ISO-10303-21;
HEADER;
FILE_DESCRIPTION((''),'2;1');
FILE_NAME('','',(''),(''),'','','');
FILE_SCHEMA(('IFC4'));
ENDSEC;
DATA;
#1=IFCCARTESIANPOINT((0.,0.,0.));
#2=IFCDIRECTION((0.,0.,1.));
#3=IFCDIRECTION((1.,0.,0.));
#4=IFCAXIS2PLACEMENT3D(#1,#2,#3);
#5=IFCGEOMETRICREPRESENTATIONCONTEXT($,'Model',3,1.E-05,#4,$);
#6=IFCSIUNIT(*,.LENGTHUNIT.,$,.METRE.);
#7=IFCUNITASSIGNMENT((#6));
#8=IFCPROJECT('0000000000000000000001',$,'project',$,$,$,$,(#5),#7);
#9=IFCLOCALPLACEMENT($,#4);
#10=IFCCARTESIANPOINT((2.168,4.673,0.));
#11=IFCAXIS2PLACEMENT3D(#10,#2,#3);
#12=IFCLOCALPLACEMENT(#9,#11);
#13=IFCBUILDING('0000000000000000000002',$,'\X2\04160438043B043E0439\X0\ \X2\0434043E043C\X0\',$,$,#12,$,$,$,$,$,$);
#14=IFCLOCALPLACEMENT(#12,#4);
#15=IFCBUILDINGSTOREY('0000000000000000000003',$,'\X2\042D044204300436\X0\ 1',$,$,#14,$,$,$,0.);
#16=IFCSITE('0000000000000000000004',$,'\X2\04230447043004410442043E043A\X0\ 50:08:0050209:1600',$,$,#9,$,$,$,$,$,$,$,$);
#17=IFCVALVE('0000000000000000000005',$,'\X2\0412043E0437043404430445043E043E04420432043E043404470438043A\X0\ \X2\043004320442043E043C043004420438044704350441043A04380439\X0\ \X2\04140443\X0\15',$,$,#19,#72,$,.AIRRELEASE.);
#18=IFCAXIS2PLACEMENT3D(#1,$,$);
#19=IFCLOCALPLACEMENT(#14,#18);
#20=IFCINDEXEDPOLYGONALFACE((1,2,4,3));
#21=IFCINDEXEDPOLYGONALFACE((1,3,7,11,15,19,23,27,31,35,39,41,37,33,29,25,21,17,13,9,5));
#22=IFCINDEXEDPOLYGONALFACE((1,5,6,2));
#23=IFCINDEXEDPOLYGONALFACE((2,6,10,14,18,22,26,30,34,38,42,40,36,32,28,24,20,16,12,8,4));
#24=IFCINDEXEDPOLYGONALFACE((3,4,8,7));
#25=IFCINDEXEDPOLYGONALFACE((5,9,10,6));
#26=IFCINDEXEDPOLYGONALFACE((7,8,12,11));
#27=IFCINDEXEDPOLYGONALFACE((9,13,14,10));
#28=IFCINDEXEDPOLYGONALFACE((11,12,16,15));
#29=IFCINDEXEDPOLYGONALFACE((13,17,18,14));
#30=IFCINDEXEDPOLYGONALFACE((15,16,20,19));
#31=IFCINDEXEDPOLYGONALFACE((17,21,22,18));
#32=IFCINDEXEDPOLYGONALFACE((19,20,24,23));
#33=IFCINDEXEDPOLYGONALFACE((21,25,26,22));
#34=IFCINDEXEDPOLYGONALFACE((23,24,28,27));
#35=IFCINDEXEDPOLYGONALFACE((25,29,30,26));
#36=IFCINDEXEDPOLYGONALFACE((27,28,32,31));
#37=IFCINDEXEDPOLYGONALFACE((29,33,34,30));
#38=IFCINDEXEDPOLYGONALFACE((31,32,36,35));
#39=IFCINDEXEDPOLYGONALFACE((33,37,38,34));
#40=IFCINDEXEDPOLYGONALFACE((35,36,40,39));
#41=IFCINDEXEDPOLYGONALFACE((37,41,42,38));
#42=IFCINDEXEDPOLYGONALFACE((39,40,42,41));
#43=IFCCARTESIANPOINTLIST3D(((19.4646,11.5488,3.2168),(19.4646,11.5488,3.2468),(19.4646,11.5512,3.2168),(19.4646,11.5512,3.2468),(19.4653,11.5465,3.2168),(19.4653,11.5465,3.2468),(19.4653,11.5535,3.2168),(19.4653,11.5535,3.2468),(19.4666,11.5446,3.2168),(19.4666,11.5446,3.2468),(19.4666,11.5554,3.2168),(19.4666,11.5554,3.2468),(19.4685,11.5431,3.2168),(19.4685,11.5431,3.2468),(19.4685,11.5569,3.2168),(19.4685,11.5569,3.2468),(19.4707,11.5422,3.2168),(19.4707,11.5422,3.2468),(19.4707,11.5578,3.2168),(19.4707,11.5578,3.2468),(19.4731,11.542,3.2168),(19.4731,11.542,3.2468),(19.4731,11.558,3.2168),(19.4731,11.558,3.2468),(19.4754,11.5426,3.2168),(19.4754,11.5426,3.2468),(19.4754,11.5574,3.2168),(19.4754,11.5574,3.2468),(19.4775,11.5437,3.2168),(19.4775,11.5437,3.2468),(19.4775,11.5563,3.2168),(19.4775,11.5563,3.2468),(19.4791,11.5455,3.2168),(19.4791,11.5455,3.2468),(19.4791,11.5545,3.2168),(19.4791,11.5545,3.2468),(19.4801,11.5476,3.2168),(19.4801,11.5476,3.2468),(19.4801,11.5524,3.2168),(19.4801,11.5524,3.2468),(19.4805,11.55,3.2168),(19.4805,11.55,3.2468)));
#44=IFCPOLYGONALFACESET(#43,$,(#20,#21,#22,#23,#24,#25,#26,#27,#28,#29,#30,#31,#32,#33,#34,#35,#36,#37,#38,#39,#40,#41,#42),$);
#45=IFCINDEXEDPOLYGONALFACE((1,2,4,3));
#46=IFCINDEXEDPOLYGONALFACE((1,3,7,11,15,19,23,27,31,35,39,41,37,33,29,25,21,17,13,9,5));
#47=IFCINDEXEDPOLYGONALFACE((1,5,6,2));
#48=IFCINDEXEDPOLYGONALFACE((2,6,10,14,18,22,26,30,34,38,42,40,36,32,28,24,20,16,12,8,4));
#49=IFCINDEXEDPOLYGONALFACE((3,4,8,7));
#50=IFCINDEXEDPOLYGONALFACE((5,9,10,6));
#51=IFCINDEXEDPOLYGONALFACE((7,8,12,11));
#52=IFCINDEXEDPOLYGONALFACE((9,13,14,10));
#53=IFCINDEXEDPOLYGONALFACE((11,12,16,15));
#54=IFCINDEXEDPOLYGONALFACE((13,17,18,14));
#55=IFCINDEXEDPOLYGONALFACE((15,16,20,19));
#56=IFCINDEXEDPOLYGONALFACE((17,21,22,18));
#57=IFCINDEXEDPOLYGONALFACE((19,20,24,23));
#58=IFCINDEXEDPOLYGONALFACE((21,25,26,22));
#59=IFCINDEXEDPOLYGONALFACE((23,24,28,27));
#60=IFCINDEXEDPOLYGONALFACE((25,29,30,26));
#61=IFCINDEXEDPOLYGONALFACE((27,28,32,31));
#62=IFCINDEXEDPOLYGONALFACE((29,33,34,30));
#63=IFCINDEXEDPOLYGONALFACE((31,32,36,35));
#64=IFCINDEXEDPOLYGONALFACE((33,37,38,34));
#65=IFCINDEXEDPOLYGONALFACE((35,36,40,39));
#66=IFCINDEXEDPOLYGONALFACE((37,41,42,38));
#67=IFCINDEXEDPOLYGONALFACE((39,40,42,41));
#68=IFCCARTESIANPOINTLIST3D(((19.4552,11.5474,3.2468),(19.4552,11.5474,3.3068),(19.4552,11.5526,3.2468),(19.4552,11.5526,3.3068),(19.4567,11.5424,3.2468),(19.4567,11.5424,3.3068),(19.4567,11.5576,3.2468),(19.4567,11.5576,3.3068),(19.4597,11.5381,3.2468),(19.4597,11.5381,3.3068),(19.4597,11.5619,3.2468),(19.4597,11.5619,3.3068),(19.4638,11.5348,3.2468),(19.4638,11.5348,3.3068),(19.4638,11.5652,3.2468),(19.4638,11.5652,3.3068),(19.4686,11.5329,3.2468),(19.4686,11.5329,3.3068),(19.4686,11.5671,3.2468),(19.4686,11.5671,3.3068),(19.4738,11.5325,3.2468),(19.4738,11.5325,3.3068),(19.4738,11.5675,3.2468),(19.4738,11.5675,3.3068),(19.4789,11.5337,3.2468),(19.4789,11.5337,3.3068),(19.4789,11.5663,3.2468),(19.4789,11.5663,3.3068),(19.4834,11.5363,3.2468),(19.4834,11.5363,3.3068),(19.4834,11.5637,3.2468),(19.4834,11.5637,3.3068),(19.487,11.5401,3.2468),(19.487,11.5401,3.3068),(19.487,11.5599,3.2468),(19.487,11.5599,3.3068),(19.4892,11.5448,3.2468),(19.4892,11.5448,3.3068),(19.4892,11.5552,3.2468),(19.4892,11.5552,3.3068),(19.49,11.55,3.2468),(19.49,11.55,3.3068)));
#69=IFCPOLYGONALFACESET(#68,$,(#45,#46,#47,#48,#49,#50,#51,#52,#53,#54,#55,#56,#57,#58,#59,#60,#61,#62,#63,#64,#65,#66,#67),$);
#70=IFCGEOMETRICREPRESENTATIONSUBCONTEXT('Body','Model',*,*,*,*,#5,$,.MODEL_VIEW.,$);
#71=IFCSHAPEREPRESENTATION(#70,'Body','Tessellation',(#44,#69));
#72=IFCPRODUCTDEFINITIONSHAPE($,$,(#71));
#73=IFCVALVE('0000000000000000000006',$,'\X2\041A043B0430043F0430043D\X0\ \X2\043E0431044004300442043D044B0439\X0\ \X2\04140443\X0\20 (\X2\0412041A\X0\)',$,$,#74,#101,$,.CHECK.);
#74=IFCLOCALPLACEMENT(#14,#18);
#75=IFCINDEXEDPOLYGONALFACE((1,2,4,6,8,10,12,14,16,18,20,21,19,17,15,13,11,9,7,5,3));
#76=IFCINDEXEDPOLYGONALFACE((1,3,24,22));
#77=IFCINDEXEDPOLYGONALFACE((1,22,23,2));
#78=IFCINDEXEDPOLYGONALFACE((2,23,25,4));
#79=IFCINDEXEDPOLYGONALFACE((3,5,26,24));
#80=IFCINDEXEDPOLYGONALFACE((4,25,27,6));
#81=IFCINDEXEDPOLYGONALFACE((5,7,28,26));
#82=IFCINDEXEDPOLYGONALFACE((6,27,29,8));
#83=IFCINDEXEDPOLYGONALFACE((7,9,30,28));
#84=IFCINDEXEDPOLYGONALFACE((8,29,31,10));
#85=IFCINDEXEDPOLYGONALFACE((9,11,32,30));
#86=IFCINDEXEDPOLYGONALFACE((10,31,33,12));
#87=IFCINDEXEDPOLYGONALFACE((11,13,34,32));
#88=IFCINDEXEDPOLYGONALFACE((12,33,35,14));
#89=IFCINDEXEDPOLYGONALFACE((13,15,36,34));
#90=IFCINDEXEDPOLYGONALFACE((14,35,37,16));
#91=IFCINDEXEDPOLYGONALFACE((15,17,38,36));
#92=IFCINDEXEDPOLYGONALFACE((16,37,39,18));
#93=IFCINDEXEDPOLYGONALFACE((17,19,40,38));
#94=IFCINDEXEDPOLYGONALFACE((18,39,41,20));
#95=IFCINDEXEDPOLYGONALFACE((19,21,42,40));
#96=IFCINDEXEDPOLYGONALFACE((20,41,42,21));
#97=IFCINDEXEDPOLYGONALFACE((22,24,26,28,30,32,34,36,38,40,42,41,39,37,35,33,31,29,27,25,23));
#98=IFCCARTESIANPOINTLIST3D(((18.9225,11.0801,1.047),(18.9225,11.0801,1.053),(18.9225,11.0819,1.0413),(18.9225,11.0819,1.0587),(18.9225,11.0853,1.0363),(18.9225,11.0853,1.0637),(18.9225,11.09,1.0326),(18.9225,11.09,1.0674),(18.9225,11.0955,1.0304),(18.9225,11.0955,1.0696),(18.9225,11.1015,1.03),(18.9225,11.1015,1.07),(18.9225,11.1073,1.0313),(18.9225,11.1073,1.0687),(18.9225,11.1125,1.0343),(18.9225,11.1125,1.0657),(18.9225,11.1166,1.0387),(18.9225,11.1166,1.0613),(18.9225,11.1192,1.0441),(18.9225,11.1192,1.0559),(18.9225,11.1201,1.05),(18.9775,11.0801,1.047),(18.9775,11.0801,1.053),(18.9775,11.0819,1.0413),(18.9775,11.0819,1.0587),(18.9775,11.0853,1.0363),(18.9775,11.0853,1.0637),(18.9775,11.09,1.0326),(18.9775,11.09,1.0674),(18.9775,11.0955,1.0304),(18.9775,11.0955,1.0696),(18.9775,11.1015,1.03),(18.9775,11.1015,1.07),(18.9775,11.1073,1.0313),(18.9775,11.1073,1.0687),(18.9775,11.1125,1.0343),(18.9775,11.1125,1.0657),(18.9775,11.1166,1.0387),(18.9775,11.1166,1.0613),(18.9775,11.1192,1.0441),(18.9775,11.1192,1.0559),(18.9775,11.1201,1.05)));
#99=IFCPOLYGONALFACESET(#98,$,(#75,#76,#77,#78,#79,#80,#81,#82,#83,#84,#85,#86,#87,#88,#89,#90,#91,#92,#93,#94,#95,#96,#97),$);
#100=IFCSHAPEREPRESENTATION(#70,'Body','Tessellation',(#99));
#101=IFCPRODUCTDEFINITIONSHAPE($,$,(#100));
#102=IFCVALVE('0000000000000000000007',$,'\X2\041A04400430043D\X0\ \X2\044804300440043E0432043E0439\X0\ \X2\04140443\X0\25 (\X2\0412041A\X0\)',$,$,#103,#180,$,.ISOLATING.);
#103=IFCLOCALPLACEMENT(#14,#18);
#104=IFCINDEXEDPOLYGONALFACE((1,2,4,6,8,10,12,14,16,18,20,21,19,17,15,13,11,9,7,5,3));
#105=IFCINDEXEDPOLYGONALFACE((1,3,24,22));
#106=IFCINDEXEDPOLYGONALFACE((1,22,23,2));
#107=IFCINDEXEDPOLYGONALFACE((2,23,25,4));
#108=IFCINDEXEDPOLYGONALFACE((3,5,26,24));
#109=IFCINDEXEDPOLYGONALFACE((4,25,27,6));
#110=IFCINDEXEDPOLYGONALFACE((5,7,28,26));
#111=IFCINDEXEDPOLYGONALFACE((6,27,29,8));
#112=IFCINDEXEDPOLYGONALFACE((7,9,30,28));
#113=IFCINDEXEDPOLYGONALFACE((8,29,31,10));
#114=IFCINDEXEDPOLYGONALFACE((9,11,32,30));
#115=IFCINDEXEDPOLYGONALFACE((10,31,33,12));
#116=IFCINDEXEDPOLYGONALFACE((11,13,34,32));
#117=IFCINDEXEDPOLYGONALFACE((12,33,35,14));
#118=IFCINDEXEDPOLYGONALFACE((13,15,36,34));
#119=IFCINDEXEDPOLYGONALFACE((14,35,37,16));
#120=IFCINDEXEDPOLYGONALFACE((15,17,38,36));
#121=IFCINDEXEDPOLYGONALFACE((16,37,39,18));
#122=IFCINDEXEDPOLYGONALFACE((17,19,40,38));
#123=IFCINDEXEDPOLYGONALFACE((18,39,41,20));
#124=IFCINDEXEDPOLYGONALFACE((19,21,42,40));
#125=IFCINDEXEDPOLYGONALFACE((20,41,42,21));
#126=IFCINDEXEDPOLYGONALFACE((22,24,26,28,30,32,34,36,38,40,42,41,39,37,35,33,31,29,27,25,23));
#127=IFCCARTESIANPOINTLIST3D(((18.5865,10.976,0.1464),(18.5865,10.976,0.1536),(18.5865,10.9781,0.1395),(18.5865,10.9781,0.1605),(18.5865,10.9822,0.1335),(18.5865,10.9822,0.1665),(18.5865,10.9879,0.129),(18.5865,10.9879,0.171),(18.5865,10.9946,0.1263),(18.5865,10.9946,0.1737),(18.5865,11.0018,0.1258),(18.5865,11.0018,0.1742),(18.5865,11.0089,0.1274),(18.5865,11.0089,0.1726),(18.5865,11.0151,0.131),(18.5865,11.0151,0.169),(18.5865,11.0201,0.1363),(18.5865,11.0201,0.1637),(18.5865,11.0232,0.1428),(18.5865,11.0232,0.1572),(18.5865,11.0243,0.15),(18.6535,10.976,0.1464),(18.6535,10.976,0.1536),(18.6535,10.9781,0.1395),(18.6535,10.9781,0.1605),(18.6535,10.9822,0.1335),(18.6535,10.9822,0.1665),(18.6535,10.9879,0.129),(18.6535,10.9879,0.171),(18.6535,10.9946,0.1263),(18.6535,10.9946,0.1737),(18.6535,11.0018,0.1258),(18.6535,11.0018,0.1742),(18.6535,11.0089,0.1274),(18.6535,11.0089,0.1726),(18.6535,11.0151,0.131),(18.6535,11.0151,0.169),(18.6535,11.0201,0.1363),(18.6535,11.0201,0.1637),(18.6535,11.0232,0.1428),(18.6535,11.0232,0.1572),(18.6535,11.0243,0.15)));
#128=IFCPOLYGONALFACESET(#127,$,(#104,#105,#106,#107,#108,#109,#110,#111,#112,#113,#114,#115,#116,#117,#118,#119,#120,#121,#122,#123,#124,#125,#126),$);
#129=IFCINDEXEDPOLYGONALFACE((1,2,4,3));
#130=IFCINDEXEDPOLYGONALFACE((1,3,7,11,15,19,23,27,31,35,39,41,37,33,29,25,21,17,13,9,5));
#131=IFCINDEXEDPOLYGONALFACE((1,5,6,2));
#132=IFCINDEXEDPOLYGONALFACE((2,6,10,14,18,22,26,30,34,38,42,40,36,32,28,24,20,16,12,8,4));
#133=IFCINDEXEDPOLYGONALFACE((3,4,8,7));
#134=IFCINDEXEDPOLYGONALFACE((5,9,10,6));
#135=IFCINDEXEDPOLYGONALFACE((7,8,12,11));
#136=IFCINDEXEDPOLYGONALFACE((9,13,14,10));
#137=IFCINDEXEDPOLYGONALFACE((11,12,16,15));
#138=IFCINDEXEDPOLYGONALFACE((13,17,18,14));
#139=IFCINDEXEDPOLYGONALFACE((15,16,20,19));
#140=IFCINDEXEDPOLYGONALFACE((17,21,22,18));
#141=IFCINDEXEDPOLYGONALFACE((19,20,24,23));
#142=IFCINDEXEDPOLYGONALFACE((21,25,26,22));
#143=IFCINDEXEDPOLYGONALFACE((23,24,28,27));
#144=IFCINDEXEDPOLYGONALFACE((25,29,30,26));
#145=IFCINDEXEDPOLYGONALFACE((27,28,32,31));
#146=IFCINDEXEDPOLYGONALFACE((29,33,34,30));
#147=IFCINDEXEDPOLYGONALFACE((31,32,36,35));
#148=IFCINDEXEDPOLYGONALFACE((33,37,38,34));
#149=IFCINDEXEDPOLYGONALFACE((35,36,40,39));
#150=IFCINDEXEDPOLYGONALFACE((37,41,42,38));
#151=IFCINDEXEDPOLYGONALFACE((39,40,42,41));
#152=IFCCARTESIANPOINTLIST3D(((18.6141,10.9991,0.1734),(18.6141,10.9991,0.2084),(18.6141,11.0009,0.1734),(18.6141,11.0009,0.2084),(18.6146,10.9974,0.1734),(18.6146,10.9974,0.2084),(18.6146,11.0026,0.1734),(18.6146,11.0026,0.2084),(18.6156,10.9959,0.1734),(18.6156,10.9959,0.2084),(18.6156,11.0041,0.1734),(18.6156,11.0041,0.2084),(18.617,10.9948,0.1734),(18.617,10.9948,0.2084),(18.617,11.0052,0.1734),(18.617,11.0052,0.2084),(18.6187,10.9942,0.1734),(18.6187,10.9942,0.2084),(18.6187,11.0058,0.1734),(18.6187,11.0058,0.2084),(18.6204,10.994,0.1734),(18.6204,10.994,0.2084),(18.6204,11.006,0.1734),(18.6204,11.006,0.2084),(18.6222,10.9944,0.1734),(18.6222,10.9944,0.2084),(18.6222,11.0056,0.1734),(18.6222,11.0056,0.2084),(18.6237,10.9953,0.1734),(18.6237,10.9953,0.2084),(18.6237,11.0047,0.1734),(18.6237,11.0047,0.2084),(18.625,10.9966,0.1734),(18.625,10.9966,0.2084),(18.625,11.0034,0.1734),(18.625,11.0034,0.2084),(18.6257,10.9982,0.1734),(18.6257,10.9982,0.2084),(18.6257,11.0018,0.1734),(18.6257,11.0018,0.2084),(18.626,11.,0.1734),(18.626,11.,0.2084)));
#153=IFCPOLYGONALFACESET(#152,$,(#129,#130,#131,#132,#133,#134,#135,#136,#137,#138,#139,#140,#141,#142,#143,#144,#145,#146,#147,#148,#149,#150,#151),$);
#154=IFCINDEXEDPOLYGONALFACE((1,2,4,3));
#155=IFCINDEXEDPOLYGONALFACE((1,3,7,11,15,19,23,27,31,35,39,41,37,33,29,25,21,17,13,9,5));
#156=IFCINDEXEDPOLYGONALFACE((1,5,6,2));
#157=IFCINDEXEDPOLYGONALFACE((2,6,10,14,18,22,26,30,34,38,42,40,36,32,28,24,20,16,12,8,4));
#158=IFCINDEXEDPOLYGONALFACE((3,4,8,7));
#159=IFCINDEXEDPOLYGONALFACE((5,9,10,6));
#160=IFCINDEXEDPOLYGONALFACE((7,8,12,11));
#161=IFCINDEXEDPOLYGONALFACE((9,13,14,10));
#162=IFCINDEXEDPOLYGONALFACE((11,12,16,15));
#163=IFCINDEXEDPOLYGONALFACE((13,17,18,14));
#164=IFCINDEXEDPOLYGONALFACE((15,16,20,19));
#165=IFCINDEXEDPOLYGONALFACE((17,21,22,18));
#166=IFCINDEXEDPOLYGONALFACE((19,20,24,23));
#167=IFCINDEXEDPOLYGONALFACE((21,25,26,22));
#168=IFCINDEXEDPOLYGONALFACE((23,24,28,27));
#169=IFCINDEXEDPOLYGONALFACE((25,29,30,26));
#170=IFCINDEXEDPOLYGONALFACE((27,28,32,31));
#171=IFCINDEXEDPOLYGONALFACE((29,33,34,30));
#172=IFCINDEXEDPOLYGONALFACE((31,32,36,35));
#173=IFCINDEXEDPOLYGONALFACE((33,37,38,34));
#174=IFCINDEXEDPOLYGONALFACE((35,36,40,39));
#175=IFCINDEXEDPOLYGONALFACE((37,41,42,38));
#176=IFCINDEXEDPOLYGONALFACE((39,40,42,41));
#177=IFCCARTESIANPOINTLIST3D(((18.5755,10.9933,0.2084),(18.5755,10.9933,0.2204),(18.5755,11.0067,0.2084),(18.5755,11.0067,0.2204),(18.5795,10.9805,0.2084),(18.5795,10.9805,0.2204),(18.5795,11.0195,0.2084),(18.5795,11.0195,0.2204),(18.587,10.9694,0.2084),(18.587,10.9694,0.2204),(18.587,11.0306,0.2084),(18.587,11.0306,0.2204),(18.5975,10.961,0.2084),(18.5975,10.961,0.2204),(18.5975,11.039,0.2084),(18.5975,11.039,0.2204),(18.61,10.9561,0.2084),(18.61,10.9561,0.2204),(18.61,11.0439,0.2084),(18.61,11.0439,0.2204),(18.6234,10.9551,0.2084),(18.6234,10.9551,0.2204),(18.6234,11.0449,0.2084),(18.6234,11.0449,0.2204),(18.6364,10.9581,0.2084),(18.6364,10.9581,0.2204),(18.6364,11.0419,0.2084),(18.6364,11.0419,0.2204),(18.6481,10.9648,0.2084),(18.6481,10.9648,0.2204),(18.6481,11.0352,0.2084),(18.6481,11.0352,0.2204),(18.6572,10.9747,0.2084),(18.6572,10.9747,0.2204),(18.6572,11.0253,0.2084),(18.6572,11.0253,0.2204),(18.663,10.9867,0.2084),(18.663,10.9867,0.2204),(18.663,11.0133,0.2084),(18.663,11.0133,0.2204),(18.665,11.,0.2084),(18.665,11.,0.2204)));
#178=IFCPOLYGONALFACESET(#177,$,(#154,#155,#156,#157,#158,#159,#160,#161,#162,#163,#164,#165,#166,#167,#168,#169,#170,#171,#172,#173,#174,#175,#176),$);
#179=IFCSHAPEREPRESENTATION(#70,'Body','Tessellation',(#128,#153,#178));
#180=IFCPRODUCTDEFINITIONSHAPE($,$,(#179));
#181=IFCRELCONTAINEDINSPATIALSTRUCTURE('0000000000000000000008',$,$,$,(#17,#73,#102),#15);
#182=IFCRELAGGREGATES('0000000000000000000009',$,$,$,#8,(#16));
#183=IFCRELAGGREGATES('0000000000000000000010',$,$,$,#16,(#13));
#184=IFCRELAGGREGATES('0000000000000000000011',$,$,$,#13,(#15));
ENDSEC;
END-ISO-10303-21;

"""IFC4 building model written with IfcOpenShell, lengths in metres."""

from ifc_helpers import new_model, si_unit, frame, origin_with_axes, origin_2d, place, context, subcontext, project, spatial, circle, extrude, element, save


model = new_model("IFC4")

# Units and contexts
model_context = context("Model", 3, precision=1e-05, world=origin_with_axes())
body_context = subcontext(model_context, "Body", "Model", "MODEL_VIEW")
ifc_project = project(units=[si_unit("LENGTHUNIT", "METRE")], contexts=[model_context])

# Site, building, storey
site_placement = place(None, origin_with_axes())
site = spatial("IfcSite", under=ifc_project, at=site_placement, Name="Участок 50:08:0050209:1600")
building_placement = place(site_placement, frame((2.168, 4.673, 0.0), z_axis=(0.0, 0.0, 1.0), x_axis=(1.0, 0.0, 0.0)))
building = spatial("IfcBuilding", under=site, at=building_placement, Name="Жилой дом")
storey_placement = place(building_placement, origin_with_axes())
storey = spatial("IfcBuildingStorey", under=building, at=storey_placement, Name="Этаж 1", Elevation=0.0)

# Valves
valve_1_placement = place(storey_placement, origin_with_axes())
element("IfcValve", 1, at=valve_1_placement, inside=storey, Name="Воздухоотводчик автоматический Ду15", PredefinedType="AIRRELEASE", context=body_context, shape_type="SweptSolid", body=[
    extrude(circle(Radius=0.008, at=origin_2d()), frame((19.4725, 11.55, 3.2168), z_axis=(0.0, 0.0, 1.0), x_axis=(1.0, 0.0, 0.0)), (0.0, 0.0, 1.0), 0.03),
    extrude(circle(Radius=0.0175, at=origin_2d()), frame((19.4725, 11.55, 3.2468), z_axis=(0.0, 0.0, 1.0), x_axis=(1.0, 0.0, 0.0)), (0.0, 0.0, 1.0), 0.06),
])
valve_2_placement = place(storey_placement, origin_with_axes())
element("IfcValve", 2, at=valve_2_placement, inside=storey, Name="Клапан обратный Ду20 (ВК)", PredefinedType="CHECK", context=body_context, shape_type="SweptSolid", body=[
    extrude(circle(Radius=0.0201, at=origin_2d()), frame((18.9225, 11.1, 1.05), z_axis=(1.0, 0.0, 0.0), x_axis=(0.0, 1.0, 0.0)), (0.0, 0.0, 1.0), 0.055),
])
valve_3_placement = place(storey_placement, origin_with_axes())
element("IfcValve", 3, at=valve_3_placement, inside=storey, Name="Кран шаровой Ду25 (ВК)", PredefinedType="ISOLATING", context=body_context, shape_type="SweptSolid", body=[
    extrude(circle(Radius=0.0243, at=origin_2d()), frame((18.5865, 11.0, 0.15), z_axis=(1.0, 0.0, 0.0), x_axis=(0.0, 1.0, 0.0)), (0.0, 0.0, 1.0), 0.067),
    extrude(circle(Radius=0.006, at=origin_2d()), frame((18.62, 11.0, 0.1734), z_axis=(0.0, 0.0, 1.0), x_axis=(1.0, 0.0, 0.0)), (0.0, 0.0, 1.0), 0.035),
    extrude(circle(Radius=0.045, at=origin_2d()), frame((18.62, 11.0, 0.2084), z_axis=(0.0, 0.0, 1.0), x_axis=(1.0, 0.0, 0.0)), (0.0, 0.0, 1.0), 0.012),
])

save(model, "model.ifc")
